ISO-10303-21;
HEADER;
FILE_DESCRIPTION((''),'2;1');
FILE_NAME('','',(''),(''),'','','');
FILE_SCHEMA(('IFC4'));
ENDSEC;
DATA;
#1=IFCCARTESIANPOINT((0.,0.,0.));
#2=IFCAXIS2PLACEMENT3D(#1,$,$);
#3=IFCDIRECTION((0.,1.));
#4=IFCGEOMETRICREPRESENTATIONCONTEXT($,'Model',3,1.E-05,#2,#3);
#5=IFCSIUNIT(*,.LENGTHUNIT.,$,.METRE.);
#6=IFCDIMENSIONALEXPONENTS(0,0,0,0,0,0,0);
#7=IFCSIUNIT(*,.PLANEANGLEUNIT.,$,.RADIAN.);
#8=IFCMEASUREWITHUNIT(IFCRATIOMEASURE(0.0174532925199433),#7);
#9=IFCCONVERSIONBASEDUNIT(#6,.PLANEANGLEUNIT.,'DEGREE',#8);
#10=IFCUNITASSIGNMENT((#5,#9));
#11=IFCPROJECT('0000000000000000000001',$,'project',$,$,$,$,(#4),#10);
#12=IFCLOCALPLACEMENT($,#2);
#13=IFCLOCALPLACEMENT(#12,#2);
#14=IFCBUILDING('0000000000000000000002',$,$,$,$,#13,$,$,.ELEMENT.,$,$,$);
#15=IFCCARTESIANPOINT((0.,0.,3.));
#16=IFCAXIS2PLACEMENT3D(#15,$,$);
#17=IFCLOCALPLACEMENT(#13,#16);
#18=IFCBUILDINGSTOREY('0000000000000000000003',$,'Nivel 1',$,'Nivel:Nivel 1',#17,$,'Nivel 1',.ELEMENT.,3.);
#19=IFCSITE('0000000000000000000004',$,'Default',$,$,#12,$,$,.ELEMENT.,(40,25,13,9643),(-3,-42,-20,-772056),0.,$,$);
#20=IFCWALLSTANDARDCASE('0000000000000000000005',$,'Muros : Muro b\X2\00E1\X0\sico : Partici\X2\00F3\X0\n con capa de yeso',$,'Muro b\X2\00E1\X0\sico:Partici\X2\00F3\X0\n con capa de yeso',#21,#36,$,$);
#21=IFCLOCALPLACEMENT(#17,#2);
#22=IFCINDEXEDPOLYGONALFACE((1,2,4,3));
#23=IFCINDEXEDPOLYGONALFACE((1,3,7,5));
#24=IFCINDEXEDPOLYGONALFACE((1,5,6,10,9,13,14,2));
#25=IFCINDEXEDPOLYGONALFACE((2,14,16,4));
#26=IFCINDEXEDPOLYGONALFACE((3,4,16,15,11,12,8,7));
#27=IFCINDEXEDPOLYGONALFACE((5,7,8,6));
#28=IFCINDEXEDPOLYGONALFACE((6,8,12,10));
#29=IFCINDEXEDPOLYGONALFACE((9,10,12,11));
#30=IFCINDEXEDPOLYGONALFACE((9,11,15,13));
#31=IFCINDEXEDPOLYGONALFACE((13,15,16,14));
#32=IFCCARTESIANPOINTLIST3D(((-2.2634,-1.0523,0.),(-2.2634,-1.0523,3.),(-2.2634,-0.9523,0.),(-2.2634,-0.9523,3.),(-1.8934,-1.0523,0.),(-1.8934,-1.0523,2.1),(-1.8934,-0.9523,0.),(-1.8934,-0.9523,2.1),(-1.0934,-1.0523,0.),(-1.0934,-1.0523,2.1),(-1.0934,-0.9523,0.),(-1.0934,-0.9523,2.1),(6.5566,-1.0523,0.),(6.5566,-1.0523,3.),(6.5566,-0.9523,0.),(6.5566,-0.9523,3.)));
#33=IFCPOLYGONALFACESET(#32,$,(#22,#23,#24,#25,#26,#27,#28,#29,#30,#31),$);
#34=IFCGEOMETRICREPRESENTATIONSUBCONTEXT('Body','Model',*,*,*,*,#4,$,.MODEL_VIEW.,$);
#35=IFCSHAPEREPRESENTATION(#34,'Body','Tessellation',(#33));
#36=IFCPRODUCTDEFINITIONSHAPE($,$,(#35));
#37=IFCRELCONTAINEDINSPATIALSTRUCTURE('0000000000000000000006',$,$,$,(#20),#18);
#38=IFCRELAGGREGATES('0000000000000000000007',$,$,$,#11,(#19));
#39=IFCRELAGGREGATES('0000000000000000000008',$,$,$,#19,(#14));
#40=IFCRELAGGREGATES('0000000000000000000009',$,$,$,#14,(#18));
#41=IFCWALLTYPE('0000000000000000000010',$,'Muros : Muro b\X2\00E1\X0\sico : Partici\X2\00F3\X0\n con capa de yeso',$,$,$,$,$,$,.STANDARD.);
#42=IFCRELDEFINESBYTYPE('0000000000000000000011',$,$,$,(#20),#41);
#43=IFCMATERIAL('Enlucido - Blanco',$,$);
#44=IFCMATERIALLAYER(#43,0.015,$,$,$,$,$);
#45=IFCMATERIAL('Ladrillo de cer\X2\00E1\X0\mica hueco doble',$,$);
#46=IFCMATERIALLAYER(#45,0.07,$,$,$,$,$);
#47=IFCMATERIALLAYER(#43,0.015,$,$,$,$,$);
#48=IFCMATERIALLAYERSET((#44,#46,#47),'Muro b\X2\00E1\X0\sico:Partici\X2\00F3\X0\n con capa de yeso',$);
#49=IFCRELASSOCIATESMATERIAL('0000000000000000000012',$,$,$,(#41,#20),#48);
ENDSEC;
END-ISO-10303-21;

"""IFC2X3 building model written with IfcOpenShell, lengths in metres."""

from ifc_helpers import new_model, entity, si_unit, converted_unit, direction, frame, frame_2d, origin, place, context, subcontext, project, spatial, rectangle, extrude, material, layer, layer_set, layer_usage, type_object, element, save


model = new_model("IFC2X3")

# Units and contexts
model_context = context("Model", 3, precision=1e-05, world=origin(), true_north=direction((0.0, 1.0)))
body_context = subcontext(model_context, "Body", "Model", "MODEL_VIEW")
ifc_project = project(units=[si_unit("LENGTHUNIT", "METRE"), converted_unit("PLANEANGLEUNIT", "DEGREE", entity("IfcRatioMeasure", 0.0174532925199433), si_unit("PLANEANGLEUNIT", "RADIAN"), dimensions=[0, 0, 0, 0, 0, 0, 0])], contexts=[model_context])

# Site, building, storey
site_placement = place(None, origin())
site = spatial("IfcSite", under=ifc_project, at=site_placement, Name="Default", CompositionType="ELEMENT", RefLatitude=(40, 25, 13, 9643), RefLongitude=(-3, -42, -20, -772056), RefElevation=0.0)
building_placement = place(site_placement, origin())
building = spatial("IfcBuilding", under=site, at=building_placement, CompositionType="ELEMENT")
storey_placement = place(building_placement, frame((0.0, 0.0, 3.0)))
storey = spatial("IfcBuildingStorey", under=building, at=storey_placement, Name="Nivel 1", ObjectType="Nivel:Nivel 1", LongName="Nivel 1", CompositionType="ELEMENT", Elevation=3.0)

# Shared definitions
ifc_material_1 = material(Name="Ladrillo de cerámica hueco doble")
ifc_material_2 = material(Name="Enlucido - Blanco")

# Wall, opening
ifc_layer_1 = layer(ifc_material_2, 0.015)
ifc_layer_2 = layer(ifc_material_1, 0.07)
ifc_layer_3 = layer(ifc_material_2, 0.015)
ifc_layer_set_1 = layer_set([ifc_layer_1, ifc_layer_2, ifc_layer_3], Name="Muro básico:Partición con capa de yeso")
ifc_layer_usage_1 = layer_usage(ifc_layer_set_1, "AXIS2", "NEGATIVE", 0.05)
wall_type_1 = type_object("IfcWallType", Name="Muros : Muro básico : Partición con capa de yeso", PredefinedType="STANDARD", material=ifc_layer_set_1)
wall_1_placement = place(storey_placement, frame((6.5566, -1.0023, 0.0), z_axis=(0.0, 0.0, 1.0), x_axis=(-1.0, 0.0, 0.0)))
wall_1 = element("IfcWallStandardCase", 1, at=wall_1_placement, inside=storey, type_object=wall_type_1, material=ifc_layer_usage_1, Name="Muros : Muro básico : Partición con capa de yeso", ObjectType="Muro básico:Partición con capa de yeso", context=body_context, shape_type="SweptSolid", body=[
    extrude(rectangle(XDim=8.82, YDim=0.1, at=frame_2d((4.41, 0.0), x_axis=(-1.0, 0.0))), origin(), (0.0, 0.0, 1.0), 3.0),
])
opening_1_placement = place(wall_1_placement, frame((7.65, -0.05, 0.0)))
element("IfcOpeningElement", 2, at=opening_1_placement, cuts=wall_1, ObjectType="Opening", context=body_context, shape_type="SweptSolid", body=[
    extrude(rectangle(XDim=2.1, YDim=0.8, at=frame_2d((1.05, 0.4), x_axis=(1.0, 0.0))), frame((0.0, 0.0, 0.0), z_axis=(0.0, 1.0, 0.0), x_axis=(0.0, 0.0, 1.0)), (0.0, 0.0, 1.0), 0.1),
])

save(model, "model.ifc")
